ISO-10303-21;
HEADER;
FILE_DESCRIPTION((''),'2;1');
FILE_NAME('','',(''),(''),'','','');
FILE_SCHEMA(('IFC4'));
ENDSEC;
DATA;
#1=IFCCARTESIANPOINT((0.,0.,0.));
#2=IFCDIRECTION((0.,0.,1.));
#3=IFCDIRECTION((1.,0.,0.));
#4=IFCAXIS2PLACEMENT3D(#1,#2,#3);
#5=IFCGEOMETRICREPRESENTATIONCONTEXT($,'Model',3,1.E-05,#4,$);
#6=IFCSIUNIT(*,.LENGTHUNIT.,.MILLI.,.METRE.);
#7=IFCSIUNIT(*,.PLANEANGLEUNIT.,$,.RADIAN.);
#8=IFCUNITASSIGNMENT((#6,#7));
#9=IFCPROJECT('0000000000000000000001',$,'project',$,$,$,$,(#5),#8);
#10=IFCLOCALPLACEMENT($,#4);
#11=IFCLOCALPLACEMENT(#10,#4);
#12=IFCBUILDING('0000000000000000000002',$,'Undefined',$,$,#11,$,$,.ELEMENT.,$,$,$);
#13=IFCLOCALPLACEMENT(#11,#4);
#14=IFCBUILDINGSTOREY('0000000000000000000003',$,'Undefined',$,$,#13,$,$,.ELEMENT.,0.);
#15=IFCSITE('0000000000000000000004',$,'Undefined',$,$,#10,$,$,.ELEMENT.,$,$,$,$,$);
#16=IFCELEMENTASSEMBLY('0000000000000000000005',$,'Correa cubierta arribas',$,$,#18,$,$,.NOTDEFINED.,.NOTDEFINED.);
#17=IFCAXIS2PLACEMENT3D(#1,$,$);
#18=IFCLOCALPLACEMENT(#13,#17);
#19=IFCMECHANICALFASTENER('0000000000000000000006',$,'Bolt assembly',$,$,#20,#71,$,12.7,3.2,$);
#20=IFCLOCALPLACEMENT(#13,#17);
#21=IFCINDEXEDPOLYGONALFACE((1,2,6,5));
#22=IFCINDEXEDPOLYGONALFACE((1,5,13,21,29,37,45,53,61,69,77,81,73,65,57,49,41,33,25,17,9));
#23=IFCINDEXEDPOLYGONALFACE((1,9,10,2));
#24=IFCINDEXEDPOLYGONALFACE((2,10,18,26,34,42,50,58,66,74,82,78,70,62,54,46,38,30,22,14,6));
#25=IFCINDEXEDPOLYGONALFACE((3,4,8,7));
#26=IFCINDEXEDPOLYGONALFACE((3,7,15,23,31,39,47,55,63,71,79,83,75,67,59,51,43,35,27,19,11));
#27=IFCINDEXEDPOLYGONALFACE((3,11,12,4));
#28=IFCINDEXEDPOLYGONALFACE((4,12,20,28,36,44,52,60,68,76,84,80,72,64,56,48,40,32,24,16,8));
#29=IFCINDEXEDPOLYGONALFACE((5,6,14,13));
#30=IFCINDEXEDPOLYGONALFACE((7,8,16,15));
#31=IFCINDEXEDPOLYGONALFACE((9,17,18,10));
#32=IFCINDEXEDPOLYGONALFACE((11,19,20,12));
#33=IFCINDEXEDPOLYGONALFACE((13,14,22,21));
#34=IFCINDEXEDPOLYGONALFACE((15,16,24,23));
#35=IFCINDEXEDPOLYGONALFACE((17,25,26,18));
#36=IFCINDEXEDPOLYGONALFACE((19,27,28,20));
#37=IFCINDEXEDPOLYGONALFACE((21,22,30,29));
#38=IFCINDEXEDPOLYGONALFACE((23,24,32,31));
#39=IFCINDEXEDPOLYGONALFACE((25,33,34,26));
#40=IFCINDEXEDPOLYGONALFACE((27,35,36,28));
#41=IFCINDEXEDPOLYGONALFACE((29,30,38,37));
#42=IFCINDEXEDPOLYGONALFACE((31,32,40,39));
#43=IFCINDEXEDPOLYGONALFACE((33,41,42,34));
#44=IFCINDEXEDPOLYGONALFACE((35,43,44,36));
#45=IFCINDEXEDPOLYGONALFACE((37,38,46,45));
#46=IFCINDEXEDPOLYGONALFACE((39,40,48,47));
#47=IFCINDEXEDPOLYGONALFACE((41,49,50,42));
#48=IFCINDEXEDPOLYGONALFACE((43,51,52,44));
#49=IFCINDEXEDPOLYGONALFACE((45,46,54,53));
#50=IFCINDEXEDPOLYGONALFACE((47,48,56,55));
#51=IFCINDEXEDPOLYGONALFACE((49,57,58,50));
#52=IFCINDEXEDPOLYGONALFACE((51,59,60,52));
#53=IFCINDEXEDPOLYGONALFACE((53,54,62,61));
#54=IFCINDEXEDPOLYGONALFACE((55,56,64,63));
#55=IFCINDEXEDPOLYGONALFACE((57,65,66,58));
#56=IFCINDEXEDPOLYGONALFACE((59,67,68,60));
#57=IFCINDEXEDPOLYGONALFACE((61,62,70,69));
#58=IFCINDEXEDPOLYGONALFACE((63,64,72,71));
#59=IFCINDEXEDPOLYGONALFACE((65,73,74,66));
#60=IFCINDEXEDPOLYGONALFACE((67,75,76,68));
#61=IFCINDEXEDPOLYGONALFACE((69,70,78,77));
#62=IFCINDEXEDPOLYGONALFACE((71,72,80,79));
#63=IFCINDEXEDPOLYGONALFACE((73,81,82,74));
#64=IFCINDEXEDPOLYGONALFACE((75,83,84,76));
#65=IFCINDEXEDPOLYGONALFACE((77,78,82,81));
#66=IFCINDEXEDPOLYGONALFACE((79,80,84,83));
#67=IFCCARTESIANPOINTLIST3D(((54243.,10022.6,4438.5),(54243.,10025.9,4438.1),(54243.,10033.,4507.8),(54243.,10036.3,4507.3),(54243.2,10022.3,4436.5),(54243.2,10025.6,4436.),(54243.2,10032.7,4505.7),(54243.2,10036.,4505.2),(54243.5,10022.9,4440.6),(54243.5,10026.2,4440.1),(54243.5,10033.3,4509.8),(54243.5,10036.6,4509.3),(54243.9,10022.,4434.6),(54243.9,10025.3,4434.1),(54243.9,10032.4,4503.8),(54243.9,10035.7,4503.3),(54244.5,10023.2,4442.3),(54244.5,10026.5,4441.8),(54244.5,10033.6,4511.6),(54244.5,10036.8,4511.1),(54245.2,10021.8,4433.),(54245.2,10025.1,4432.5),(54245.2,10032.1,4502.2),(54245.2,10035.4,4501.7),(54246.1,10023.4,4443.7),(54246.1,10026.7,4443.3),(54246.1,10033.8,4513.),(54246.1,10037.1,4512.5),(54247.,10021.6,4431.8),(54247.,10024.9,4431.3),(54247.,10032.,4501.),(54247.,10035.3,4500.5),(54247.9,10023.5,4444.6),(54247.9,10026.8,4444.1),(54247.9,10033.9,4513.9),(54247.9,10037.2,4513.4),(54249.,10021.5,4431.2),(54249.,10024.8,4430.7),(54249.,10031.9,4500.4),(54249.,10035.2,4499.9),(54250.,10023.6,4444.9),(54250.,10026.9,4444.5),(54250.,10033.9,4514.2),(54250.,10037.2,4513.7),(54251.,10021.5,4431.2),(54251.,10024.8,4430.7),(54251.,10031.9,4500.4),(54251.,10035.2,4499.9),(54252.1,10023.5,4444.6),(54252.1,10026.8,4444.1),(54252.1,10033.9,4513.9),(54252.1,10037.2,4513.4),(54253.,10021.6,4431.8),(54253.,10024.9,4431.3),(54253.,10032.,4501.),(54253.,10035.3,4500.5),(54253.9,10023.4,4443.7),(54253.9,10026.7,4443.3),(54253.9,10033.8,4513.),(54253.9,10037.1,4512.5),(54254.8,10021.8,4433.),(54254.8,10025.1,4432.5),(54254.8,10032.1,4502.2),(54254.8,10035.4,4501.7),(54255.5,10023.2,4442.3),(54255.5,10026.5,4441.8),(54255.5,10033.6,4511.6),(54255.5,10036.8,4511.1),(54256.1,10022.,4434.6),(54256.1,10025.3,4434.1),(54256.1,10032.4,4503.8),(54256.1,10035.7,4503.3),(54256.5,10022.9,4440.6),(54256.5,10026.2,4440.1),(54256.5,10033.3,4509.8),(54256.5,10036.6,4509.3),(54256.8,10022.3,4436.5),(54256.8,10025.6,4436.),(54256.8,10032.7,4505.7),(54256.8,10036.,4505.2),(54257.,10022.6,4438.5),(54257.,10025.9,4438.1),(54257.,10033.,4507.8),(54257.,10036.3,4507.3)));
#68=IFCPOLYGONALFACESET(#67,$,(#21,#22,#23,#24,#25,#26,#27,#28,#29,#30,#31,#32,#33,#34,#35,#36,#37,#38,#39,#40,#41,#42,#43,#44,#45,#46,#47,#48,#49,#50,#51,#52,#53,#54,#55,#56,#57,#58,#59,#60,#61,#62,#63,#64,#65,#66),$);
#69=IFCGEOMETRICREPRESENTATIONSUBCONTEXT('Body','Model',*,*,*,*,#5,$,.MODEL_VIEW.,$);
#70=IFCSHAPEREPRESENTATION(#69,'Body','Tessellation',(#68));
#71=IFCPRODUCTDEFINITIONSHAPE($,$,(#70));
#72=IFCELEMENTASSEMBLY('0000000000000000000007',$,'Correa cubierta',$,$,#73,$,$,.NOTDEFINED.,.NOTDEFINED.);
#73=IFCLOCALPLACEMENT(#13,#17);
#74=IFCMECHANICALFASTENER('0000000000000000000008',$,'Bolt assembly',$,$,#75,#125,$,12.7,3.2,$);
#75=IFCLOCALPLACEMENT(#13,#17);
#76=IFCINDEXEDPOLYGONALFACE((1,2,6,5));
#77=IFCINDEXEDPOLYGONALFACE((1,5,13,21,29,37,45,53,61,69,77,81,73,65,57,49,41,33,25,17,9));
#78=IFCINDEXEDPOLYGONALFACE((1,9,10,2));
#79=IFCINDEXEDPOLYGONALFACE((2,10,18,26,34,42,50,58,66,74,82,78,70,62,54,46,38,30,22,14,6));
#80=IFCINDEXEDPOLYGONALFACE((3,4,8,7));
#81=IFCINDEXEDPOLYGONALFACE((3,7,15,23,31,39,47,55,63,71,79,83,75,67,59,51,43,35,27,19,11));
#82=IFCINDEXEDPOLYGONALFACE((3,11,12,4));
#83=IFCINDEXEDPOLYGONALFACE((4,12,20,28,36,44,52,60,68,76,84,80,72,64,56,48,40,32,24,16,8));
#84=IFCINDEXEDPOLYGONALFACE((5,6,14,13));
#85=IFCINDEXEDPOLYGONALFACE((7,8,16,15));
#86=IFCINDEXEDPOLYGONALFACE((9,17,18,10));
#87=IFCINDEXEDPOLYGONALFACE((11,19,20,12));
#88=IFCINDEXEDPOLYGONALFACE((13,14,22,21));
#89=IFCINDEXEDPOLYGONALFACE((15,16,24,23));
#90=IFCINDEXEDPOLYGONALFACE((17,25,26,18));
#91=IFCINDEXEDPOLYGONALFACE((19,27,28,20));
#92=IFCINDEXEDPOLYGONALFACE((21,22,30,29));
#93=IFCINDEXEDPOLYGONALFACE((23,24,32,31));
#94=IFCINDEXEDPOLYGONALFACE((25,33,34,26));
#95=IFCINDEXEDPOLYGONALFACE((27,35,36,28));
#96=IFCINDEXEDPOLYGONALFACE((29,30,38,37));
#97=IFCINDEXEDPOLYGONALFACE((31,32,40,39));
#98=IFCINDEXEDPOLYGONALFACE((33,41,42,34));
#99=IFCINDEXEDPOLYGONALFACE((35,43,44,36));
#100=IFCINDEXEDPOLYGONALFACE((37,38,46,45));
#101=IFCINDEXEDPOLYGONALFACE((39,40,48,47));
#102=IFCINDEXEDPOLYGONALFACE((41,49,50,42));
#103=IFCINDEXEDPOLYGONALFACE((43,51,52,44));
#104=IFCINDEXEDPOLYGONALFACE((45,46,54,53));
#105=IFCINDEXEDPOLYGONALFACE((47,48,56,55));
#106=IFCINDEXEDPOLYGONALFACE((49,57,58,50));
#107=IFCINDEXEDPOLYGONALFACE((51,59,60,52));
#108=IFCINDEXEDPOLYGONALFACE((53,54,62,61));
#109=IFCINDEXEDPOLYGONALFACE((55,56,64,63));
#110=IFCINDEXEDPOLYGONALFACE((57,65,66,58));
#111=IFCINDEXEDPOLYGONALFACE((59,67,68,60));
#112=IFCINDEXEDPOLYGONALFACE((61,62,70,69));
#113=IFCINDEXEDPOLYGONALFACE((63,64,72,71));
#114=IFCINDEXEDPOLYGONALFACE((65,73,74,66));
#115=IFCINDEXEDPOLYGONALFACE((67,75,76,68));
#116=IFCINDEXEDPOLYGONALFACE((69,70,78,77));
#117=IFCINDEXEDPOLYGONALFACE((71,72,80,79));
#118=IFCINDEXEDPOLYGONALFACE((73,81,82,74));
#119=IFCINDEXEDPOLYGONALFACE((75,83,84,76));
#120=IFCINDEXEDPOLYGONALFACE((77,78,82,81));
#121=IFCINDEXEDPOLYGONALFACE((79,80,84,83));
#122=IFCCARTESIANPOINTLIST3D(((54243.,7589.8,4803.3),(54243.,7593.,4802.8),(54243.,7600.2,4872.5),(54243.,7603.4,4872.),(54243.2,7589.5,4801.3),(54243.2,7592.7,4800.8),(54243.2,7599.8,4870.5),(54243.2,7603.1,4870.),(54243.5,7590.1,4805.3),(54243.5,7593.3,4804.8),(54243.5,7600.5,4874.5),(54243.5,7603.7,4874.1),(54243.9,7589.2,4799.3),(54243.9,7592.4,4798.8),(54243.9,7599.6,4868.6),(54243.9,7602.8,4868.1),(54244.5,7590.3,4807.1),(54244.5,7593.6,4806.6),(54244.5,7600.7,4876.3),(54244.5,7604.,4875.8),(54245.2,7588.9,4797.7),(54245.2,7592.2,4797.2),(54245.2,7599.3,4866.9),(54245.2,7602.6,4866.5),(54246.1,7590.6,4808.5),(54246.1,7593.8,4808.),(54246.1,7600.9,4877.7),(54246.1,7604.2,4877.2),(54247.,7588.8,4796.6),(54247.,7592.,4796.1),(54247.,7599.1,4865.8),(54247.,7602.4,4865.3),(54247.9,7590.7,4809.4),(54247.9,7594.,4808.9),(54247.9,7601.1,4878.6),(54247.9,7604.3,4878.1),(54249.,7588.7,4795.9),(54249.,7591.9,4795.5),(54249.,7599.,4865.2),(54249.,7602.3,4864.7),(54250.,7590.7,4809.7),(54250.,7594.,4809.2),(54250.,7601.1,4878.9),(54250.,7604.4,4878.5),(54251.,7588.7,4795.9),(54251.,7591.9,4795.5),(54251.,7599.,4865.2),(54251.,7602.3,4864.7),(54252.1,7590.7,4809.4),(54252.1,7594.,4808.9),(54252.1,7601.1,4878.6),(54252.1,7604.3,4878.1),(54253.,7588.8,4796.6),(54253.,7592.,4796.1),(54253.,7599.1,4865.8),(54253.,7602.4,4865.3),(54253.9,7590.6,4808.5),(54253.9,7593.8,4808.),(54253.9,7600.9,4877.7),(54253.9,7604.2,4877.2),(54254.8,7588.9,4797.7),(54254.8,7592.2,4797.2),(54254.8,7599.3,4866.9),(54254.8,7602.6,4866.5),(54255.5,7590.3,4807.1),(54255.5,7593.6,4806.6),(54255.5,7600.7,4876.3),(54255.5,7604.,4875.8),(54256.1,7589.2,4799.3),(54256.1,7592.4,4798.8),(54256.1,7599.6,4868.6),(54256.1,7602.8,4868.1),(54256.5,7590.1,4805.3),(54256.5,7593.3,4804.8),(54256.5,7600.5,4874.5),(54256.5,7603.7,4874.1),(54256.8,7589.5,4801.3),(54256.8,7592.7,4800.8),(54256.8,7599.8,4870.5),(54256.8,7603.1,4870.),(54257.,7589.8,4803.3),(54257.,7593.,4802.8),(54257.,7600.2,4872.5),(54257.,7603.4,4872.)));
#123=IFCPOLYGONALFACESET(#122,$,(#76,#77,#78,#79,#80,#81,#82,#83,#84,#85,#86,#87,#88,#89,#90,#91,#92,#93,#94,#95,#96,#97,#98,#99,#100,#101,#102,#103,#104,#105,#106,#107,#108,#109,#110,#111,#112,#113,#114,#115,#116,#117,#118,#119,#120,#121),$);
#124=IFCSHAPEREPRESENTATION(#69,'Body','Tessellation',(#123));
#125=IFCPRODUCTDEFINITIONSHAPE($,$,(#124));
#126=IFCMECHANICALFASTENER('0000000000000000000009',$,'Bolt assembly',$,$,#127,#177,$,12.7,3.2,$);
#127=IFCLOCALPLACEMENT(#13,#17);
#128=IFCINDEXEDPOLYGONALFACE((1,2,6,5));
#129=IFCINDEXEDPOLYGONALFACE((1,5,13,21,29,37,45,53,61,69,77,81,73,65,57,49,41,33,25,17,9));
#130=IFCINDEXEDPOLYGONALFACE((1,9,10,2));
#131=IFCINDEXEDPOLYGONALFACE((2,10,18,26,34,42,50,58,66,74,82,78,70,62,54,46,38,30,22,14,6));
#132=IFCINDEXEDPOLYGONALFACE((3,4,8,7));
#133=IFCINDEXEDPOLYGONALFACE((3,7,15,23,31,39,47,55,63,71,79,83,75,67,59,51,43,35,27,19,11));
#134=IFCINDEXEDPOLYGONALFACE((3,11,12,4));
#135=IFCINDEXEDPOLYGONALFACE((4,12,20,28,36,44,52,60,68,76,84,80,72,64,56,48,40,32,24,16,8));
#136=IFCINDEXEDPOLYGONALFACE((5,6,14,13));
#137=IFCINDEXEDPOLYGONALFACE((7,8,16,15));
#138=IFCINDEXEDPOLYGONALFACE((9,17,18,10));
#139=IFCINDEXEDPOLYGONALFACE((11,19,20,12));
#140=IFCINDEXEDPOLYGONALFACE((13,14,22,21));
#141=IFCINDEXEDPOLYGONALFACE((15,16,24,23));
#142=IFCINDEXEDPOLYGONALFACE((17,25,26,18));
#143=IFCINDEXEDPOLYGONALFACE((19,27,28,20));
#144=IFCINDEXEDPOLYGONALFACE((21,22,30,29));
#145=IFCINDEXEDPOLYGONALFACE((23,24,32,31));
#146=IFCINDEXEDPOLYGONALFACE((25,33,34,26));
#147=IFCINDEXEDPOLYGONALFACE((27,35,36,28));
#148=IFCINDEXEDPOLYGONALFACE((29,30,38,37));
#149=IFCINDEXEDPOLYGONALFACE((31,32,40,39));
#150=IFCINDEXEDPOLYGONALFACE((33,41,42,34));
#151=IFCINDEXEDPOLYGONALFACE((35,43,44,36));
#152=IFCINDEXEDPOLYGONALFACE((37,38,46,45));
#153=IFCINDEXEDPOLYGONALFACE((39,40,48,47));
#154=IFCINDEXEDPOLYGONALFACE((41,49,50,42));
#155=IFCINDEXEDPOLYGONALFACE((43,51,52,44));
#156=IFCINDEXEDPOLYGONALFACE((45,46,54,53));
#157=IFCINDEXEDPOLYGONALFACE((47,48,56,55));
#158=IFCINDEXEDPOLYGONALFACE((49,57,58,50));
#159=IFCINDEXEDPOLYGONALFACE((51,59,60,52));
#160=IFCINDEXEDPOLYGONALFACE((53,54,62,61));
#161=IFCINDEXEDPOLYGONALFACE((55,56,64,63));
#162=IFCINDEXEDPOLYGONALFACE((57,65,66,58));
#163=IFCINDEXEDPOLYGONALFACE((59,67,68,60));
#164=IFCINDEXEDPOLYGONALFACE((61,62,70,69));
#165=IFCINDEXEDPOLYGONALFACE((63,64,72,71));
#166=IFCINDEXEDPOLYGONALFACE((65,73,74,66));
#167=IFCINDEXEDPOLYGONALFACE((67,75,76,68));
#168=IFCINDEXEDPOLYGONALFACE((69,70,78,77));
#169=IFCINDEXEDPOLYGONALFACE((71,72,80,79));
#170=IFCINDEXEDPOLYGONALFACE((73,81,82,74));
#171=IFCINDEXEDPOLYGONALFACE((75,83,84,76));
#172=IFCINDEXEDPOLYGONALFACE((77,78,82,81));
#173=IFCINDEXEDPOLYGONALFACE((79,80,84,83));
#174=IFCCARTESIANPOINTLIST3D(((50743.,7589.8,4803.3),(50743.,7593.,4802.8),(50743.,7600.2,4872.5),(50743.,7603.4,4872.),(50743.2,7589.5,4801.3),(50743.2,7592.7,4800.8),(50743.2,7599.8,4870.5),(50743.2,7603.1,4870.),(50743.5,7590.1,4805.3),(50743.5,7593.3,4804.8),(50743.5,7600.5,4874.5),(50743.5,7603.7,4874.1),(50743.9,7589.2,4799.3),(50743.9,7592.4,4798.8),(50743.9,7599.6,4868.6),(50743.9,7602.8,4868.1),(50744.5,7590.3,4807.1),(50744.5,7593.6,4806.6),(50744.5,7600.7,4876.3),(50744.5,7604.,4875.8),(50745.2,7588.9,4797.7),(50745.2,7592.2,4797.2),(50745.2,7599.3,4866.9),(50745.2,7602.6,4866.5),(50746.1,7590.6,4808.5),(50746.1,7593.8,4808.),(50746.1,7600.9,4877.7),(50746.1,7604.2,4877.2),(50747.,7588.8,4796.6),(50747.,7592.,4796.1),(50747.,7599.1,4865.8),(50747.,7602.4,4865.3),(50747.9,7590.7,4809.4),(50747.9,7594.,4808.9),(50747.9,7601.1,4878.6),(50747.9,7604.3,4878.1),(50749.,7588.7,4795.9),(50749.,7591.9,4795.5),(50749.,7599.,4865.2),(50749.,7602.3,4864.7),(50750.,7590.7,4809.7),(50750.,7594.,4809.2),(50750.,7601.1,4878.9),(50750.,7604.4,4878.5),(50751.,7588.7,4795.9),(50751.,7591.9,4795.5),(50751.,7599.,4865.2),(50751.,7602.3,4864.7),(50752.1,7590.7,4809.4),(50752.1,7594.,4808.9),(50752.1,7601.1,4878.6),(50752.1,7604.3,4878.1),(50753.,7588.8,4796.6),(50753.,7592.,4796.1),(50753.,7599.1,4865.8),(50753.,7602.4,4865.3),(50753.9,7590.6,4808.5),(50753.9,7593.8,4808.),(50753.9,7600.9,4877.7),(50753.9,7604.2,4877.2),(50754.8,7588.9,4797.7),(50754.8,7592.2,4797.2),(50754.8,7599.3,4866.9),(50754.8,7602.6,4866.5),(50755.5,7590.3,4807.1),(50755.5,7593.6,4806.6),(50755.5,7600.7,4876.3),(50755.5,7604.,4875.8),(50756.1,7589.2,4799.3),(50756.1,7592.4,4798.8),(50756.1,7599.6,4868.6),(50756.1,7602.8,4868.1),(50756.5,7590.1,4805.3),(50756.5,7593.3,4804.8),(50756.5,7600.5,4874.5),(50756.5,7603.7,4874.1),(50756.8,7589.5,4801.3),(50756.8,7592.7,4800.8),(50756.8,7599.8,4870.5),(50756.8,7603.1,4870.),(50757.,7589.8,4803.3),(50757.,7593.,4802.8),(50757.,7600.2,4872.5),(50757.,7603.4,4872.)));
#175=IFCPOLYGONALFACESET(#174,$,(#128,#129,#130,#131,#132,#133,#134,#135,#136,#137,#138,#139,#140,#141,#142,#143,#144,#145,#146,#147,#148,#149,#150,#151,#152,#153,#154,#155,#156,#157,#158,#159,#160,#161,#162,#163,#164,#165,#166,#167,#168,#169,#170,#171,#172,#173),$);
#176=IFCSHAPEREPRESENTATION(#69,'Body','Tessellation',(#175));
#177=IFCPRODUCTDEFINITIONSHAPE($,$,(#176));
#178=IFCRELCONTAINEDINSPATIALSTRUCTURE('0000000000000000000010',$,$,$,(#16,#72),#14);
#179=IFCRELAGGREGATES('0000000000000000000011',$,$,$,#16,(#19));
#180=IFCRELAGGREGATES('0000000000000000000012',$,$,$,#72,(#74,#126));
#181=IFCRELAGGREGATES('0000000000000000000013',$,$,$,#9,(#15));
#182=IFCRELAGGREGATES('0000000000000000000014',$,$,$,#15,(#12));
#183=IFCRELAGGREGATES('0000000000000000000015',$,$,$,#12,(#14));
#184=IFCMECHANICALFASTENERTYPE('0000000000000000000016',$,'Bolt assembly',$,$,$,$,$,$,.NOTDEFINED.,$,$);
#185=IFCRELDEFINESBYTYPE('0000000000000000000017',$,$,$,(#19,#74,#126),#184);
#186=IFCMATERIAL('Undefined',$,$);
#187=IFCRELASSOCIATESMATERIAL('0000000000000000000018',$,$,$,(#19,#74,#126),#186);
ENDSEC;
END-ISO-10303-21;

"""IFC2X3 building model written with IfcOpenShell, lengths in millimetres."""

from ifc_helpers import new_model, si_unit, frame, origin_with_axes, origin_2d_with_axis, place, context, subcontext, project, spatial, circle, extrude, source, transform, mapped, material, type_object, element, aggregate, save


model = new_model("IFC2X3")

# Units and contexts
model_context = context("Model", 3, precision=1e-05, world=origin_with_axes())
body_context = subcontext(model_context, "Body", "Model", "MODEL_VIEW")
ifc_project = project(units=[si_unit("LENGTHUNIT", "METRE", prefix="MILLI"), si_unit("PLANEANGLEUNIT", "RADIAN")], contexts=[model_context])

# Site, building, storey
site_placement = place(None, origin_with_axes())
site = spatial("IfcSite", under=ifc_project, at=site_placement, Name="Undefined", CompositionType="ELEMENT")
building_placement = place(site_placement, origin_with_axes())
building = spatial("IfcBuilding", under=site, at=building_placement, Name="Undefined", CompositionType="ELEMENT")
storey_placement = place(building_placement, origin_with_axes())
storey = spatial("IfcBuildingStorey", under=building, at=storey_placement, Name="Undefined", CompositionType="ELEMENT", Elevation=0.0)

# Element assembly, mechanical fastener
ifc_material_1 = material(Name="Undefined")
mechanical_fastener_type = type_object("IfcMechanicalFastenerType", Name="Bolt assembly")
assembly_1_placement = place(storey_placement, origin_with_axes())
assembly_1 = element("IfcElementAssembly", 1, at=assembly_1_placement, inside=storey, Name="Correa cubierta arribas", AssemblyPlace="NOTDEFINED", PredefinedType="NOTDEFINED")
shared_shape_1 = source(origin_with_axes(), body_context, "Body", "SweptSolid", [
    extrude(circle(Radius=7.0, at=origin_2d_with_axis()), frame((0.0, 6.4, 0.0), z_axis=(0.0, 1.0, 0.0), x_axis=(1.0, 0.0, 0.0)), (0.0, 0.0, 1.0), 3.3),
])
mechanical_fastener_1_placement = place(assembly_1_placement, frame((54250.0, 10016.2, 4439.0), z_axis=(-1.0, 0.0, 0.0), x_axis=(0.0, 0.148209, 0.988956)))
mechanical_fastener_1 = element("IfcMechanicalFastener", 2, at=mechanical_fastener_1_placement, type_object=mechanical_fastener_type, material=ifc_material_1, Name="Bolt assembly", NominalDiameter=12.7, NominalLength=3.2, context=body_context, shape_type="MappedRepresentation", body=[
    mapped(shared_shape_1, transform((0.0, 0.0, 0.0))),
    mapped(shared_shape_1, transform((70.0, 0.0, 0.0))),
])
aggregate(assembly_1, [mechanical_fastener_1])

# Element assembly, mechanical fasteners
assembly_2_placement = place(storey_placement, origin_with_axes())
assembly_2 = element("IfcElementAssembly", 3, at=assembly_2_placement, inside=storey, Name="Correa cubierta", AssemblyPlace="NOTDEFINED", PredefinedType="NOTDEFINED")
shared_shape_2 = source(origin_with_axes(), body_context, "Body", "SweptSolid", [
    extrude(circle(Radius=7.0, at=origin_2d_with_axis()), frame((0.0, 3.2, 0.0), z_axis=(0.0, 1.0, 0.0), x_axis=(1.0, 0.0, 0.0)), (0.0, 0.0, 1.0), 3.3),
])
mechanical_fastener_2_placement = place(assembly_2_placement, frame((54250.0, 7586.5, 4803.3), z_axis=(-1.0, 0.0, 0.0), x_axis=(0.0, 0.148209, 0.988956)))
mechanical_fastener_2 = element("IfcMechanicalFastener", 4, at=mechanical_fastener_2_placement, type_object=mechanical_fastener_type, material=ifc_material_1, Name="Bolt assembly", NominalDiameter=12.7, NominalLength=3.2, context=body_context, shape_type="MappedRepresentation", body=[
    mapped(shared_shape_2, transform((0.0, 0.0, 0.0))),
    mapped(shared_shape_2, transform((70.0, 0.0, 0.0))),
])
mechanical_fastener_3_placement = place(assembly_2_placement, frame((50750.0, 7586.5, 4803.3), z_axis=(-1.0, 0.0, 0.0), x_axis=(0.0, 0.148209, 0.988956)))
mechanical_fastener_3 = element("IfcMechanicalFastener", 5, at=mechanical_fastener_3_placement, type_object=mechanical_fastener_type, material=ifc_material_1, Name="Bolt assembly", NominalDiameter=12.7, NominalLength=3.2, context=body_context, shape_type="MappedRepresentation", body=[
    mapped(shared_shape_2, transform((0.0, 0.0, 0.0))),
    mapped(shared_shape_2, transform((70.0, 0.0, 0.0))),
])

aggregate(assembly_2, [mechanical_fastener_2, mechanical_fastener_3])

save(model, "model.ifc")
